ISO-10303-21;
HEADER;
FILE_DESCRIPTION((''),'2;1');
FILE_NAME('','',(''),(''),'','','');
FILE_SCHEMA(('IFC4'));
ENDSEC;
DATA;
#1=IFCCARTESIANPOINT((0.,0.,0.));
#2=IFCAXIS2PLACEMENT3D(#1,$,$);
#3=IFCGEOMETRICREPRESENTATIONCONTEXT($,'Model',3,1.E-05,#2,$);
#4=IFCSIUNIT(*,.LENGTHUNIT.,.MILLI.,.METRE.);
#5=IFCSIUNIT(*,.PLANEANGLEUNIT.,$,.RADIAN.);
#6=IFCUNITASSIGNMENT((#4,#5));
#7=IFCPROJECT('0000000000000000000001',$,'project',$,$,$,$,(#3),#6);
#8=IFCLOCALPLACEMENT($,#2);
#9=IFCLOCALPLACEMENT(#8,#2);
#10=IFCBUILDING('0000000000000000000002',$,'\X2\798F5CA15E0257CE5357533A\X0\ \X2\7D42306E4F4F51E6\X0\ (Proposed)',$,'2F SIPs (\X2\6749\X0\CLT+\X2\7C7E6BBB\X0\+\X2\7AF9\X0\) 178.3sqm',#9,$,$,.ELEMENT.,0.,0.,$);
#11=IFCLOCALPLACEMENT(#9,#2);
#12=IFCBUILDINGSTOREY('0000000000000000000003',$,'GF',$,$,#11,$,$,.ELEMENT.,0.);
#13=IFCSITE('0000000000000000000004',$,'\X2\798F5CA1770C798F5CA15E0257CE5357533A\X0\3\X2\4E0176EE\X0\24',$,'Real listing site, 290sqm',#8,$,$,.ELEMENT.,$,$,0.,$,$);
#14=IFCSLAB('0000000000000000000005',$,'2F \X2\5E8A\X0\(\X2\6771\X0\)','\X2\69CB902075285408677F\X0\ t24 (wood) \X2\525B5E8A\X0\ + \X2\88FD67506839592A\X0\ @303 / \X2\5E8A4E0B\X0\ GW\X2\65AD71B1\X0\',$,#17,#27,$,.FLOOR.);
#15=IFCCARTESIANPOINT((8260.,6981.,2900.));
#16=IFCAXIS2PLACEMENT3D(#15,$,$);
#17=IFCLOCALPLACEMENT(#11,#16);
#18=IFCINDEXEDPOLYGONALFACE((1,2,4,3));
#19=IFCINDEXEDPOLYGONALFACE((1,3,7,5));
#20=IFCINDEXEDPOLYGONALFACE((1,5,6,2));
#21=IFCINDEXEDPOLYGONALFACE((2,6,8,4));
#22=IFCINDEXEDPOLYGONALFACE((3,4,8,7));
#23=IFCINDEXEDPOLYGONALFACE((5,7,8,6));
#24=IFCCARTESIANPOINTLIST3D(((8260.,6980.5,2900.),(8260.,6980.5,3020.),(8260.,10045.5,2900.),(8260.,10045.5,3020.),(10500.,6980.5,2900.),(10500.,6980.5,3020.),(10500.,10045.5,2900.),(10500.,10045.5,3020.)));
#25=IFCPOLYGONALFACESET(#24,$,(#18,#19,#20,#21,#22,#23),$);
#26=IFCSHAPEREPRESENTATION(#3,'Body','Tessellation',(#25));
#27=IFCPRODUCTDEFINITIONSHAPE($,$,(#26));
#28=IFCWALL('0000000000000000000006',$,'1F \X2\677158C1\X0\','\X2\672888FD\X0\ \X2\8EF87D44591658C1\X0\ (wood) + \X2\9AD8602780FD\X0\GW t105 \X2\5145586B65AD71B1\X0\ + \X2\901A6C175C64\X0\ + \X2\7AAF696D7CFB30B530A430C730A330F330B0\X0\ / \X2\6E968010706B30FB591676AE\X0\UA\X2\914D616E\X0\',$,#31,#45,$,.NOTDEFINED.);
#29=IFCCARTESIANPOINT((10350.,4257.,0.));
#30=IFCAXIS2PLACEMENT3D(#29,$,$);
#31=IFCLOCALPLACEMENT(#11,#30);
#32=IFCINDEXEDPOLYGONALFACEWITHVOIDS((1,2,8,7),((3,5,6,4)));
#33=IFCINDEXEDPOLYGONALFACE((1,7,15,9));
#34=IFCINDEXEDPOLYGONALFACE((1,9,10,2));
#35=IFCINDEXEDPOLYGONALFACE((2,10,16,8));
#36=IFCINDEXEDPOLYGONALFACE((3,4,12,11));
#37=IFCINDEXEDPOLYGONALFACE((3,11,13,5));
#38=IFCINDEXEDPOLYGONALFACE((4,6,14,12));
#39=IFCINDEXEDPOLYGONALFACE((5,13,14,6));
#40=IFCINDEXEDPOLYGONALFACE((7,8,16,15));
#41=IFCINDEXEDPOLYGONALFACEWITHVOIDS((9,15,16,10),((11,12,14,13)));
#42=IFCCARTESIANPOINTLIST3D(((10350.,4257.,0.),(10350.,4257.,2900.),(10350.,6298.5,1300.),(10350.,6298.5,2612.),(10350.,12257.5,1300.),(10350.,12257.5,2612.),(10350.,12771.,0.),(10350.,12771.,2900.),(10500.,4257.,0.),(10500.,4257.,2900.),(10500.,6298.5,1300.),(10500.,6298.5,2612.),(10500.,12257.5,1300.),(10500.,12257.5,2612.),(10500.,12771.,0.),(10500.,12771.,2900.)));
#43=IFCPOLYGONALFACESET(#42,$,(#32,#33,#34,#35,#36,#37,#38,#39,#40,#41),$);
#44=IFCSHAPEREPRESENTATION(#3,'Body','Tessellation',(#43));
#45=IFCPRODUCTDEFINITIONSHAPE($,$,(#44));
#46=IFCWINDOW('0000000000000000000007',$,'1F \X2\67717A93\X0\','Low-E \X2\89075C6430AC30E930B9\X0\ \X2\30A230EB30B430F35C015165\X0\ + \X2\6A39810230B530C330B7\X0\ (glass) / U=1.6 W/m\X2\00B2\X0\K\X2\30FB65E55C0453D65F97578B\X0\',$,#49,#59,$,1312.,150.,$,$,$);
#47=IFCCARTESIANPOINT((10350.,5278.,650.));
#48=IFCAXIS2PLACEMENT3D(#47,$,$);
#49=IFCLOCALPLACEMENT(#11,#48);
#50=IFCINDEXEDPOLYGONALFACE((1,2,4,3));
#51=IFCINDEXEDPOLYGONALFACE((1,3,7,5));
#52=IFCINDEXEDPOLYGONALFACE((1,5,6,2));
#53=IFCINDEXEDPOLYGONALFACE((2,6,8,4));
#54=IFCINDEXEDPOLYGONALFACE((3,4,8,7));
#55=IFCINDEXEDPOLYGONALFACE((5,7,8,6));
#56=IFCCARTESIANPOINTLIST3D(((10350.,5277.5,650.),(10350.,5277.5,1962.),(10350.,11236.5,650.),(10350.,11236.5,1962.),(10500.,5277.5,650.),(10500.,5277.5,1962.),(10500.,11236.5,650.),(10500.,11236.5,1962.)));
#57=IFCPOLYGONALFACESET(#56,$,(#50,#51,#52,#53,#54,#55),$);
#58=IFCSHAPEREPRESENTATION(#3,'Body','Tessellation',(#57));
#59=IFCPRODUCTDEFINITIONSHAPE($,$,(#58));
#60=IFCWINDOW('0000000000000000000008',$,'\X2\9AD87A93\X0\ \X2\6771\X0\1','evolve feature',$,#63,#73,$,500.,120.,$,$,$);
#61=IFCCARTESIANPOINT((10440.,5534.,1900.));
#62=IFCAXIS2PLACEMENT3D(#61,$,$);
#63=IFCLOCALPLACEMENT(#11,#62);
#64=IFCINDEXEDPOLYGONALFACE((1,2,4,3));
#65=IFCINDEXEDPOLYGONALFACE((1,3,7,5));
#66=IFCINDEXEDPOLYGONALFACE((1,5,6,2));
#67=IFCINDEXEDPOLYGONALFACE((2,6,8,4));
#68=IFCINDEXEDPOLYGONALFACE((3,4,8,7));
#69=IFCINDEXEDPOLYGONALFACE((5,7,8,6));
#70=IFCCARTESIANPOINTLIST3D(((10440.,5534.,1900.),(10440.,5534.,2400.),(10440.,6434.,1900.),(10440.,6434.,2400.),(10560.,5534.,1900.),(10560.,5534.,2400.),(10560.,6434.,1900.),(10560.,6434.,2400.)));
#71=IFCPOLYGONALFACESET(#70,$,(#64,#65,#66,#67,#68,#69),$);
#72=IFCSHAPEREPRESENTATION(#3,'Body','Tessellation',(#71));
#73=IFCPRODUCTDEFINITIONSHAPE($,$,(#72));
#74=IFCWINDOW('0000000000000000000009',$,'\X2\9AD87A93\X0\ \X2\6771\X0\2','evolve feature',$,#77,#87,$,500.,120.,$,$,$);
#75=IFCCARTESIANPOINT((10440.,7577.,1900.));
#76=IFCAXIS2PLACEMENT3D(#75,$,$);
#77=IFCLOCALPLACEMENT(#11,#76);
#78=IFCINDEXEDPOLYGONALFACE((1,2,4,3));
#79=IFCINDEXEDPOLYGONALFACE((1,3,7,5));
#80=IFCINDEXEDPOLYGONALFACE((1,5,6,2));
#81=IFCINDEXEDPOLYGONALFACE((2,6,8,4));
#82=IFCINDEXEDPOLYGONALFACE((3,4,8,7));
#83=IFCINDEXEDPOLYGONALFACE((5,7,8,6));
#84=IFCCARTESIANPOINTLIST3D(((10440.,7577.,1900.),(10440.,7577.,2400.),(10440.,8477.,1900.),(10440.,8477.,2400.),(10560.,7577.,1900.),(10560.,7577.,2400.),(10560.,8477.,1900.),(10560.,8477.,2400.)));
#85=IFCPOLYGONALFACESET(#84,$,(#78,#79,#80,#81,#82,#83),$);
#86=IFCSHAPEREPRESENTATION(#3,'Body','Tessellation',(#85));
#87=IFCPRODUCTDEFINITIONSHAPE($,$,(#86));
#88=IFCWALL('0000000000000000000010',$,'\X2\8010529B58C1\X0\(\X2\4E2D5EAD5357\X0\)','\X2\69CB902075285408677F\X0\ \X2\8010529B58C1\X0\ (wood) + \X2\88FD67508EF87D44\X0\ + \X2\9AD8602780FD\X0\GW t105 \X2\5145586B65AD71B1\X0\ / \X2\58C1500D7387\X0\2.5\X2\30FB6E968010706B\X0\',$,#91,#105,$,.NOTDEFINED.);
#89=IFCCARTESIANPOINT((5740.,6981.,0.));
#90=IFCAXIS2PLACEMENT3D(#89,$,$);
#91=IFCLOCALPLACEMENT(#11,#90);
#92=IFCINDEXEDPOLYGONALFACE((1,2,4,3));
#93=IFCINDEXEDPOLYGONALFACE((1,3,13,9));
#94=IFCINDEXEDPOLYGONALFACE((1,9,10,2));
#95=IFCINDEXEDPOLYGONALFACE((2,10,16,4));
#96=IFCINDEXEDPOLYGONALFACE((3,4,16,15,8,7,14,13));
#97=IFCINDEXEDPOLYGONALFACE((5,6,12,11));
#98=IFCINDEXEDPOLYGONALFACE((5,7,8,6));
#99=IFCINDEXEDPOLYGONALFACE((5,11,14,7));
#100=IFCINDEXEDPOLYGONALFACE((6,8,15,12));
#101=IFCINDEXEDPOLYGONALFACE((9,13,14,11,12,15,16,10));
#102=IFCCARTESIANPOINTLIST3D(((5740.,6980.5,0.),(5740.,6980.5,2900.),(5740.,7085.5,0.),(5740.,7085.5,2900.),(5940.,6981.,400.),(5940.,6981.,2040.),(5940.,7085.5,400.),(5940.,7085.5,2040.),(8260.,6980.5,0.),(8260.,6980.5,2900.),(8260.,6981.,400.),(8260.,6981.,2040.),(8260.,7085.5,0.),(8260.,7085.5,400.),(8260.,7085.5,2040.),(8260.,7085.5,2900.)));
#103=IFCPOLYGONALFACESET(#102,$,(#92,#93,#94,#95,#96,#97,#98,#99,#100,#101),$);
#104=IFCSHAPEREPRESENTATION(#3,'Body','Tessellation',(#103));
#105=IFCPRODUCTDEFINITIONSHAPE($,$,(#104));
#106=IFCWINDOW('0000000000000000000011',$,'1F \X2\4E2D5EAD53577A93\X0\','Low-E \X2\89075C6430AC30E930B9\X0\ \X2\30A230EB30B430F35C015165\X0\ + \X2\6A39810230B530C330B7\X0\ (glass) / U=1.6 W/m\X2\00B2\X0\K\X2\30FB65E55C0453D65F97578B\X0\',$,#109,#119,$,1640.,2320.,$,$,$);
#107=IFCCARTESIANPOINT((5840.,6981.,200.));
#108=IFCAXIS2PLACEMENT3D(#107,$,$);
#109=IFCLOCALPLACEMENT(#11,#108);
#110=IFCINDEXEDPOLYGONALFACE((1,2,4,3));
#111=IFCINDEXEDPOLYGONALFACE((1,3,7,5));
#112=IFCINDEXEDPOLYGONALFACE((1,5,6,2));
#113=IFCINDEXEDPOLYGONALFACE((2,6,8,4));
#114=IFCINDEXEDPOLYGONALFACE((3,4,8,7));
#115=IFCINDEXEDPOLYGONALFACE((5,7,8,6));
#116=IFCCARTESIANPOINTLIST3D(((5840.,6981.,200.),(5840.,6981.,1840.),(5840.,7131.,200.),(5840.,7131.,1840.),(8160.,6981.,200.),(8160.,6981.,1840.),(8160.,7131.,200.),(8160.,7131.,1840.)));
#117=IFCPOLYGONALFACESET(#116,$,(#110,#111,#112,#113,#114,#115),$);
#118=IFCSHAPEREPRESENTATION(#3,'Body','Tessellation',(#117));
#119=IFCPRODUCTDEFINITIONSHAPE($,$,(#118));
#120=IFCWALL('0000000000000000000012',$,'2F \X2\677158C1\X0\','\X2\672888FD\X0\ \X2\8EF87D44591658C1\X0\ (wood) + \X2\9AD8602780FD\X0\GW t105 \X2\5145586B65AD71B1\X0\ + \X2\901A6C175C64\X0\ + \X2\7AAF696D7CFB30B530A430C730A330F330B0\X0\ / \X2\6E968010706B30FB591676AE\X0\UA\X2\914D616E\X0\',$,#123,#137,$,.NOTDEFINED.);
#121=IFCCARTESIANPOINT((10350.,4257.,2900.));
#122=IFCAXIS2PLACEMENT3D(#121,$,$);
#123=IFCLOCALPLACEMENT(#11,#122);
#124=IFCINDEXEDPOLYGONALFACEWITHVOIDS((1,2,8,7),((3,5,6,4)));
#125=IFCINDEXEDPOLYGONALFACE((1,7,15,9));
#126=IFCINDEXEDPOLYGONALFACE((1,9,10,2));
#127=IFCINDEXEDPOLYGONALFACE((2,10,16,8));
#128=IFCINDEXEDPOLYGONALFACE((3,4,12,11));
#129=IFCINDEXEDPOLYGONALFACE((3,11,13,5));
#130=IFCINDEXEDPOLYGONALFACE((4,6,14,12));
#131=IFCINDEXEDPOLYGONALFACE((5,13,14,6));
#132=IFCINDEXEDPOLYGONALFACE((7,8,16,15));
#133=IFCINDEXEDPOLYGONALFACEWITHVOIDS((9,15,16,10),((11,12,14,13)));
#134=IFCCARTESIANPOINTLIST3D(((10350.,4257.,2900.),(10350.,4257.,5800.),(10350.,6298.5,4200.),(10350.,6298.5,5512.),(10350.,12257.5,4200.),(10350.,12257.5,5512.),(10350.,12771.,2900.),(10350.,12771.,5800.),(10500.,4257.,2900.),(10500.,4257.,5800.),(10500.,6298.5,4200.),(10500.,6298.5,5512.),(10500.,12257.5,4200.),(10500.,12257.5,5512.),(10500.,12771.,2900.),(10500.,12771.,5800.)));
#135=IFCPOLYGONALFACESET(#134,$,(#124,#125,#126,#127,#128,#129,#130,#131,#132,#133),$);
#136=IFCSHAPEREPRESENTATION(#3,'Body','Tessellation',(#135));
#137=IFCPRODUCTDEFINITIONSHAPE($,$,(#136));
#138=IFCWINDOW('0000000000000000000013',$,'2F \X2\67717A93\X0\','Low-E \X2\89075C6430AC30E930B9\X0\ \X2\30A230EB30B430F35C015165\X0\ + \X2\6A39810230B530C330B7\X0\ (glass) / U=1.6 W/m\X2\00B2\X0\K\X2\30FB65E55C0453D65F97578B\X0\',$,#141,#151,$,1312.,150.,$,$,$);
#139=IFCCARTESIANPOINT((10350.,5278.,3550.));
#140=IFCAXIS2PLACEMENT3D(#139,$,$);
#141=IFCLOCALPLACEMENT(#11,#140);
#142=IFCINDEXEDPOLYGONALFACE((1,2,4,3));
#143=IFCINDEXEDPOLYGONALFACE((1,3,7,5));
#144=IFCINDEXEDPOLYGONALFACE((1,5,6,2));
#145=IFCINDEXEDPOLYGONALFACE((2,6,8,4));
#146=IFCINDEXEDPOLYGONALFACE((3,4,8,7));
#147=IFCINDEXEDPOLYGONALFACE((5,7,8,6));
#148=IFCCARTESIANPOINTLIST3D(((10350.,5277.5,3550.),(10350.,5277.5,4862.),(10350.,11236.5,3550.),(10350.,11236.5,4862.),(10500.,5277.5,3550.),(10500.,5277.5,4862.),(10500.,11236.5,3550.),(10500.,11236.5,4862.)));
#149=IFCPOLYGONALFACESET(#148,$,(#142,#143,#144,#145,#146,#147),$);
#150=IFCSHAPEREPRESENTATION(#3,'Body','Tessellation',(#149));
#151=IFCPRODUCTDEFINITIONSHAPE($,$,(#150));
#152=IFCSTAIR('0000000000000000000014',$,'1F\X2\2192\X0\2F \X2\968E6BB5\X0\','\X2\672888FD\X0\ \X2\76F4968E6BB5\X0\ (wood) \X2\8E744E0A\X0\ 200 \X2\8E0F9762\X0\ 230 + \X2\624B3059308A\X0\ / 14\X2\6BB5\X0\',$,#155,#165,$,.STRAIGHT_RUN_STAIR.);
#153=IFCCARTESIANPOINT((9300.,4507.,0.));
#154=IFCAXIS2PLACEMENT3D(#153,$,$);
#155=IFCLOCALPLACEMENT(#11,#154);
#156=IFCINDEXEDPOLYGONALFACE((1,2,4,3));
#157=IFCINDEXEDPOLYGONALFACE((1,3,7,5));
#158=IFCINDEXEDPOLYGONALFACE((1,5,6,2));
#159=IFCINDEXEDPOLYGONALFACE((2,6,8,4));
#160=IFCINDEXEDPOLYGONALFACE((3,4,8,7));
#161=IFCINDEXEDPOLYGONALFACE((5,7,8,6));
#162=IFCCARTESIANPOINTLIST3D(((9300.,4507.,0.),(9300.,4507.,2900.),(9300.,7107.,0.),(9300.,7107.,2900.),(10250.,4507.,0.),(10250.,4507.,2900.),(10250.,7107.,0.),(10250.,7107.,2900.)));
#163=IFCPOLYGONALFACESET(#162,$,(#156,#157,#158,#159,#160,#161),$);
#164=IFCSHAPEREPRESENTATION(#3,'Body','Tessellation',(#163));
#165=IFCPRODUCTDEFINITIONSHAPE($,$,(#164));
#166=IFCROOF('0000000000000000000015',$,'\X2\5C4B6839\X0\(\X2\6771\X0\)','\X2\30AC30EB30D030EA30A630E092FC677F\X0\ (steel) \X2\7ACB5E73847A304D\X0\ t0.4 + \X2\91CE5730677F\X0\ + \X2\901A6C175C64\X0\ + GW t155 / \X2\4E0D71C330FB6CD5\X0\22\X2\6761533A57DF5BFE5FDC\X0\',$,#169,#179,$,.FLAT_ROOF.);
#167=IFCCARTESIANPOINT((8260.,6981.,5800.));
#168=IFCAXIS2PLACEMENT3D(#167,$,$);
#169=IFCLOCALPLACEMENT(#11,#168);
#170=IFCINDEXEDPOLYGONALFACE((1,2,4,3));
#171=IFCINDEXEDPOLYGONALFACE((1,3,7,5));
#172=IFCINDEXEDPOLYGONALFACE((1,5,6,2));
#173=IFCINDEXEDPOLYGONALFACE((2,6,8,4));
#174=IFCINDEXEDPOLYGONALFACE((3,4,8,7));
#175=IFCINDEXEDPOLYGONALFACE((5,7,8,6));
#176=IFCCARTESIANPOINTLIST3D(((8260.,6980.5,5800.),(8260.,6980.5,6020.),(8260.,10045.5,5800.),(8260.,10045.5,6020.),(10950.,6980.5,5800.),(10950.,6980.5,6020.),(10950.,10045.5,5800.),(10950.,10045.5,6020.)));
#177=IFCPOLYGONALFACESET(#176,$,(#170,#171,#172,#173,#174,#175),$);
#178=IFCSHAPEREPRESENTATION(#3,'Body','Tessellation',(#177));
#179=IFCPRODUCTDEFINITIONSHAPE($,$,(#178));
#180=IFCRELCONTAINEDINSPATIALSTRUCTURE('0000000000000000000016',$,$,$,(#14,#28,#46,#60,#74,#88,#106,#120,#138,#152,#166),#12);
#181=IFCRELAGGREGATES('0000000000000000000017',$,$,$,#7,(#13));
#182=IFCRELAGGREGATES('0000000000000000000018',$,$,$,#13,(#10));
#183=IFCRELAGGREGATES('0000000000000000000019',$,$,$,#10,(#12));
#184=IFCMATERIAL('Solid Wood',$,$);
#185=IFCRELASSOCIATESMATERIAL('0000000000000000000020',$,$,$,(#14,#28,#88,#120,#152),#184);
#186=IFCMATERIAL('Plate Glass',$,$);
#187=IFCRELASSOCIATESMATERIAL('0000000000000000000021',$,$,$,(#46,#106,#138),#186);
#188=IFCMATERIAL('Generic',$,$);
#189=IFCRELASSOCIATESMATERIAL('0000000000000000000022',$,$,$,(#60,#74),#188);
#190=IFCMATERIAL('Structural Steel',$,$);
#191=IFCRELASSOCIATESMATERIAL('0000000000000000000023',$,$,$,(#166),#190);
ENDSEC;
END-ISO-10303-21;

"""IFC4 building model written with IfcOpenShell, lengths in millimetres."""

from ifc_helpers import new_model, si_unit, frame, frame_2d, origin, place, context, project, spatial, rectangle, extrude, material, element, fill, save


model = new_model("IFC4")

# Units and contexts
model_context = context("Model", 3, precision=1e-05, world=origin())
ifc_project = project(units=[si_unit("LENGTHUNIT", "METRE", prefix="MILLI"), si_unit("PLANEANGLEUNIT", "RADIAN")], contexts=[model_context])

# Site, building, storey
site_placement = place(None, origin())
site = spatial("IfcSite", under=ifc_project, at=site_placement, Name="福岡県福岡市城南区3丁目24", ObjectType="Real listing site, 290sqm", CompositionType="ELEMENT", RefElevation=0.0)
building_placement = place(site_placement, origin())
building = spatial("IfcBuilding", under=site, at=building_placement, Name="福岡市城南区 終の住処 (Proposed)", ObjectType="2F SIPs (杉CLT+籾殻+竹) 178.3sqm", CompositionType="ELEMENT", ElevationOfRefHeight=0.0, ElevationOfTerrain=0.0)
storey_placement = place(building_placement, origin())
storey = spatial("IfcBuildingStorey", under=building, at=storey_placement, Name="GF", CompositionType="ELEMENT", Elevation=0.0)

# Slab
ifc_material_1 = material(Name="Solid Wood")
slab_1_placement = place(storey_placement, frame((8260.0, 6981.0, 2900.0)))
element("IfcSlab", 1, at=slab_1_placement, inside=storey, material=ifc_material_1, Name="2F 床(東)", Description="構造用合板 t24 (wood) 剛床 + 製材根太 @303 / 床下 GW断熱", PredefinedType="FLOOR", context=model_context, shape_type="SweptSolid", body=[
    extrude(rectangle(XDim=2240.0, YDim=3065.0, at=frame_2d((1120.0, 1532.0))), frame((8260.0, 6981.0, 2900.0)), (0.0, 0.0, 1.0), 120.0),
])

# Wall, openings, windows
wall_1_placement = place(storey_placement, frame((10350.0, 4257.0, 0.0)))
wall_1 = element("IfcWall", 2, at=wall_1_placement, inside=storey, material=ifc_material_1, Name="1F 東壁", Description="木製 軸組外壁 (wood) + 高性能GW t105 充填断熱 + 通気層 + 窯業系サイディング / 準耐火・外皮UA配慮", PredefinedType="NOTDEFINED", context=model_context, shape_type="SweptSolid", body=[
    extrude(rectangle(XDim=150.0, YDim=8514.0, at=frame_2d((75.0, 4257.0))), frame((10350.0, 4257.0, 0.0)), (0.0, 0.0, 1.0), 2900.0),
])
opening_1_placement = place(storey_placement, frame((10350.0, 5278.0, 650.0)))
opening_1 = element("IfcOpeningElement", 3, at=opening_1_placement, cuts=wall_1, PredefinedType="NOTDEFINED", context=model_context, shape_type="SweptSolid", body=[
    extrude(rectangle(XDim=150.0, YDim=5959.0, at=frame_2d((75.0, 2979.0))), frame((10350.0, 5278.0, 650.0)), (0.0, 0.0, 1.0), 1312.0),
])
opening_2_placement = place(storey_placement, frame((10440.0, 5534.0, 1900.0)))
opening_2 = element("IfcOpeningElement", 4, at=opening_2_placement, cuts=wall_1, PredefinedType="NOTDEFINED", context=model_context, shape_type="SweptSolid", body=[
    extrude(rectangle(XDim=120.0, YDim=900.0, at=frame_2d((60.0, 450.0))), frame((10440.0, 5534.0, 1900.0)), (0.0, 0.0, 1.0), 500.0),
])
opening_3_placement = place(storey_placement, frame((10440.0, 7577.0, 1900.0)))
opening_3 = element("IfcOpeningElement", 5, at=opening_3_placement, cuts=wall_1, PredefinedType="NOTDEFINED", context=model_context, shape_type="SweptSolid", body=[
    extrude(rectangle(XDim=120.0, YDim=900.0, at=frame_2d((60.0, 450.0))), frame((10440.0, 7577.0, 1900.0)), (0.0, 0.0, 1.0), 500.0),
])
ifc_material_2 = material(Name="Plate Glass")
window_1_placement = place(storey_placement, frame((10350.0, 5278.0, 650.0)))
window_1 = element("IfcWindow", 6, at=window_1_placement, inside=storey, material=ifc_material_2, Name="1F 東窓", Description="Low-E 複層ガラス アルゴン封入 + 樹脂サッシ (glass) / U=1.6 W/m²K・日射取得型", OverallHeight=1312.0, OverallWidth=150.0, context=model_context, shape_type="SweptSolid", body=[
    extrude(rectangle(XDim=150.0, YDim=5959.0, at=frame_2d((75.0, 2979.0))), frame((10350.0, 5278.0, 650.0)), (0.0, 0.0, 1.0), 1312.0),
])
fill(opening_1, window_1)
ifc_material_3 = material(Name="Generic")
window_2_placement = place(storey_placement, frame((10440.0, 5534.0, 1900.0)))
window_2 = element("IfcWindow", 7, at=window_2_placement, inside=storey, material=ifc_material_3, Name="高窓 東1", Description="evolve feature", OverallHeight=500.0, OverallWidth=120.0, context=model_context, shape_type="SweptSolid", body=[
    extrude(rectangle(XDim=120.0, YDim=900.0, at=frame_2d((60.0, 450.0))), frame((10440.0, 5534.0, 1900.0)), (0.0, 0.0, 1.0), 500.0),
])
fill(opening_2, window_2)
window_3_placement = place(storey_placement, frame((10440.0, 7577.0, 1900.0)))
window_3 = element("IfcWindow", 8, at=window_3_placement, inside=storey, material=ifc_material_3, Name="高窓 東2", Description="evolve feature", OverallHeight=500.0, OverallWidth=120.0, context=model_context, shape_type="SweptSolid", body=[
    extrude(rectangle(XDim=120.0, YDim=900.0, at=frame_2d((60.0, 450.0))), frame((10440.0, 7577.0, 1900.0)), (0.0, 0.0, 1.0), 500.0),
])
fill(opening_3, window_3)

# Wall, opening, window
wall_2_placement = place(storey_placement, frame((5740.0, 6981.0, 0.0)))
wall_2 = element("IfcWall", 9, at=wall_2_placement, inside=storey, material=ifc_material_1, Name="耐力壁(中庭南)", Description="構造用合板 耐力壁 (wood) + 製材軸組 + 高性能GW t105 充填断熱 / 壁倍率2.5・準耐火", PredefinedType="NOTDEFINED", context=model_context, shape_type="SweptSolid", body=[
    extrude(rectangle(XDim=2520.0, YDim=105.0, at=frame_2d((1260.0, 52.0))), frame((5740.0, 6981.0, 0.0)), (0.0, 0.0, 1.0), 2900.0),
])
opening_4_placement = place(storey_placement, frame((5840.0, 6981.0, 200.0)))
opening_4 = element("IfcOpeningElement", 10, at=opening_4_placement, cuts=wall_2, PredefinedType="NOTDEFINED", context=model_context, shape_type="SweptSolid", body=[
    extrude(rectangle(XDim=2320.0, YDim=150.0, at=frame_2d((1160.0, 75.0))), frame((5840.0, 6981.0, 200.0)), (0.0, 0.0, 1.0), 1640.0),
])
window_4_placement = place(storey_placement, frame((5840.0, 6981.0, 200.0)))
window_4 = element("IfcWindow", 11, at=window_4_placement, inside=storey, material=ifc_material_2, Name="1F 中庭南窓", Description="Low-E 複層ガラス アルゴン封入 + 樹脂サッシ (glass) / U=1.6 W/m²K・日射取得型", OverallHeight=1640.0, OverallWidth=2320.0, context=model_context, shape_type="SweptSolid", body=[
    extrude(rectangle(XDim=2320.0, YDim=150.0, at=frame_2d((1160.0, 75.0))), frame((5840.0, 6981.0, 200.0)), (0.0, 0.0, 1.0), 1640.0),
])
fill(opening_4, window_4)

# Wall, opening, window
wall_3_placement = place(storey_placement, frame((10350.0, 4257.0, 2900.0)))
wall_3 = element("IfcWall", 12, at=wall_3_placement, inside=storey, material=ifc_material_1, Name="2F 東壁", Description="木製 軸組外壁 (wood) + 高性能GW t105 充填断熱 + 通気層 + 窯業系サイディング / 準耐火・外皮UA配慮", PredefinedType="NOTDEFINED", context=model_context, shape_type="SweptSolid", body=[
    extrude(rectangle(XDim=150.0, YDim=8514.0, at=frame_2d((75.0, 4257.0))), frame((10350.0, 4257.0, 2900.0)), (0.0, 0.0, 1.0), 2900.0),
])
opening_5_placement = place(storey_placement, frame((10350.0, 5278.0, 3550.0)))
opening_5 = element("IfcOpeningElement", 13, at=opening_5_placement, cuts=wall_3, PredefinedType="NOTDEFINED", context=model_context, shape_type="SweptSolid", body=[
    extrude(rectangle(XDim=150.0, YDim=5959.0, at=frame_2d((75.0, 2979.0))), frame((10350.0, 5278.0, 3550.0)), (0.0, 0.0, 1.0), 1312.0),
])
window_5_placement = place(storey_placement, frame((10350.0, 5278.0, 3550.0)))
window_5 = element("IfcWindow", 14, at=window_5_placement, inside=storey, material=ifc_material_2, Name="2F 東窓", Description="Low-E 複層ガラス アルゴン封入 + 樹脂サッシ (glass) / U=1.6 W/m²K・日射取得型", OverallHeight=1312.0, OverallWidth=150.0, context=model_context, shape_type="SweptSolid", body=[
    extrude(rectangle(XDim=150.0, YDim=5959.0, at=frame_2d((75.0, 2979.0))), frame((10350.0, 5278.0, 3550.0)), (0.0, 0.0, 1.0), 1312.0),
])
fill(opening_5, window_5)

# Stair
stair_placement = place(storey_placement, frame((9300.0, 4507.0, 0.0)))
element("IfcStair", 15, at=stair_placement, inside=storey, material=ifc_material_1, Name="1F→2F 階段", Description="木製 直階段 (wood) 蹴上 200 踏面 230 + 手すり / 14段", PredefinedType="STRAIGHT_RUN_STAIR", context=model_context, shape_type="SweptSolid", body=[
    extrude(rectangle(XDim=950.0, YDim=2600.0, at=frame_2d((475.0, 1300.0))), frame((9300.0, 4507.0, 0.0)), (0.0, 0.0, 1.0), 2900.0),
])

# Roof
ifc_material_4 = material(Name="Structural Steel")
roof_placement = place(storey_placement, frame((8260.0, 6981.0, 5800.0)))
element("IfcRoof", 16, at=roof_placement, inside=storey, material=ifc_material_4, Name="屋根(東)", Description="ガルバリウム鋼板 (steel) 立平葺き t0.4 + 野地板 + 通気層 + GW t155 / 不燃・法22条区域対応", PredefinedType="FLAT_ROOF", context=model_context, shape_type="SweptSolid", body=[
    extrude(rectangle(XDim=2690.0, YDim=3065.0, at=frame_2d((1345.0, 1532.0))), frame((8260.0, 6981.0, 5800.0)), (0.0, 0.0, 1.0), 220.0),
])

save(model, "model.ifc")
